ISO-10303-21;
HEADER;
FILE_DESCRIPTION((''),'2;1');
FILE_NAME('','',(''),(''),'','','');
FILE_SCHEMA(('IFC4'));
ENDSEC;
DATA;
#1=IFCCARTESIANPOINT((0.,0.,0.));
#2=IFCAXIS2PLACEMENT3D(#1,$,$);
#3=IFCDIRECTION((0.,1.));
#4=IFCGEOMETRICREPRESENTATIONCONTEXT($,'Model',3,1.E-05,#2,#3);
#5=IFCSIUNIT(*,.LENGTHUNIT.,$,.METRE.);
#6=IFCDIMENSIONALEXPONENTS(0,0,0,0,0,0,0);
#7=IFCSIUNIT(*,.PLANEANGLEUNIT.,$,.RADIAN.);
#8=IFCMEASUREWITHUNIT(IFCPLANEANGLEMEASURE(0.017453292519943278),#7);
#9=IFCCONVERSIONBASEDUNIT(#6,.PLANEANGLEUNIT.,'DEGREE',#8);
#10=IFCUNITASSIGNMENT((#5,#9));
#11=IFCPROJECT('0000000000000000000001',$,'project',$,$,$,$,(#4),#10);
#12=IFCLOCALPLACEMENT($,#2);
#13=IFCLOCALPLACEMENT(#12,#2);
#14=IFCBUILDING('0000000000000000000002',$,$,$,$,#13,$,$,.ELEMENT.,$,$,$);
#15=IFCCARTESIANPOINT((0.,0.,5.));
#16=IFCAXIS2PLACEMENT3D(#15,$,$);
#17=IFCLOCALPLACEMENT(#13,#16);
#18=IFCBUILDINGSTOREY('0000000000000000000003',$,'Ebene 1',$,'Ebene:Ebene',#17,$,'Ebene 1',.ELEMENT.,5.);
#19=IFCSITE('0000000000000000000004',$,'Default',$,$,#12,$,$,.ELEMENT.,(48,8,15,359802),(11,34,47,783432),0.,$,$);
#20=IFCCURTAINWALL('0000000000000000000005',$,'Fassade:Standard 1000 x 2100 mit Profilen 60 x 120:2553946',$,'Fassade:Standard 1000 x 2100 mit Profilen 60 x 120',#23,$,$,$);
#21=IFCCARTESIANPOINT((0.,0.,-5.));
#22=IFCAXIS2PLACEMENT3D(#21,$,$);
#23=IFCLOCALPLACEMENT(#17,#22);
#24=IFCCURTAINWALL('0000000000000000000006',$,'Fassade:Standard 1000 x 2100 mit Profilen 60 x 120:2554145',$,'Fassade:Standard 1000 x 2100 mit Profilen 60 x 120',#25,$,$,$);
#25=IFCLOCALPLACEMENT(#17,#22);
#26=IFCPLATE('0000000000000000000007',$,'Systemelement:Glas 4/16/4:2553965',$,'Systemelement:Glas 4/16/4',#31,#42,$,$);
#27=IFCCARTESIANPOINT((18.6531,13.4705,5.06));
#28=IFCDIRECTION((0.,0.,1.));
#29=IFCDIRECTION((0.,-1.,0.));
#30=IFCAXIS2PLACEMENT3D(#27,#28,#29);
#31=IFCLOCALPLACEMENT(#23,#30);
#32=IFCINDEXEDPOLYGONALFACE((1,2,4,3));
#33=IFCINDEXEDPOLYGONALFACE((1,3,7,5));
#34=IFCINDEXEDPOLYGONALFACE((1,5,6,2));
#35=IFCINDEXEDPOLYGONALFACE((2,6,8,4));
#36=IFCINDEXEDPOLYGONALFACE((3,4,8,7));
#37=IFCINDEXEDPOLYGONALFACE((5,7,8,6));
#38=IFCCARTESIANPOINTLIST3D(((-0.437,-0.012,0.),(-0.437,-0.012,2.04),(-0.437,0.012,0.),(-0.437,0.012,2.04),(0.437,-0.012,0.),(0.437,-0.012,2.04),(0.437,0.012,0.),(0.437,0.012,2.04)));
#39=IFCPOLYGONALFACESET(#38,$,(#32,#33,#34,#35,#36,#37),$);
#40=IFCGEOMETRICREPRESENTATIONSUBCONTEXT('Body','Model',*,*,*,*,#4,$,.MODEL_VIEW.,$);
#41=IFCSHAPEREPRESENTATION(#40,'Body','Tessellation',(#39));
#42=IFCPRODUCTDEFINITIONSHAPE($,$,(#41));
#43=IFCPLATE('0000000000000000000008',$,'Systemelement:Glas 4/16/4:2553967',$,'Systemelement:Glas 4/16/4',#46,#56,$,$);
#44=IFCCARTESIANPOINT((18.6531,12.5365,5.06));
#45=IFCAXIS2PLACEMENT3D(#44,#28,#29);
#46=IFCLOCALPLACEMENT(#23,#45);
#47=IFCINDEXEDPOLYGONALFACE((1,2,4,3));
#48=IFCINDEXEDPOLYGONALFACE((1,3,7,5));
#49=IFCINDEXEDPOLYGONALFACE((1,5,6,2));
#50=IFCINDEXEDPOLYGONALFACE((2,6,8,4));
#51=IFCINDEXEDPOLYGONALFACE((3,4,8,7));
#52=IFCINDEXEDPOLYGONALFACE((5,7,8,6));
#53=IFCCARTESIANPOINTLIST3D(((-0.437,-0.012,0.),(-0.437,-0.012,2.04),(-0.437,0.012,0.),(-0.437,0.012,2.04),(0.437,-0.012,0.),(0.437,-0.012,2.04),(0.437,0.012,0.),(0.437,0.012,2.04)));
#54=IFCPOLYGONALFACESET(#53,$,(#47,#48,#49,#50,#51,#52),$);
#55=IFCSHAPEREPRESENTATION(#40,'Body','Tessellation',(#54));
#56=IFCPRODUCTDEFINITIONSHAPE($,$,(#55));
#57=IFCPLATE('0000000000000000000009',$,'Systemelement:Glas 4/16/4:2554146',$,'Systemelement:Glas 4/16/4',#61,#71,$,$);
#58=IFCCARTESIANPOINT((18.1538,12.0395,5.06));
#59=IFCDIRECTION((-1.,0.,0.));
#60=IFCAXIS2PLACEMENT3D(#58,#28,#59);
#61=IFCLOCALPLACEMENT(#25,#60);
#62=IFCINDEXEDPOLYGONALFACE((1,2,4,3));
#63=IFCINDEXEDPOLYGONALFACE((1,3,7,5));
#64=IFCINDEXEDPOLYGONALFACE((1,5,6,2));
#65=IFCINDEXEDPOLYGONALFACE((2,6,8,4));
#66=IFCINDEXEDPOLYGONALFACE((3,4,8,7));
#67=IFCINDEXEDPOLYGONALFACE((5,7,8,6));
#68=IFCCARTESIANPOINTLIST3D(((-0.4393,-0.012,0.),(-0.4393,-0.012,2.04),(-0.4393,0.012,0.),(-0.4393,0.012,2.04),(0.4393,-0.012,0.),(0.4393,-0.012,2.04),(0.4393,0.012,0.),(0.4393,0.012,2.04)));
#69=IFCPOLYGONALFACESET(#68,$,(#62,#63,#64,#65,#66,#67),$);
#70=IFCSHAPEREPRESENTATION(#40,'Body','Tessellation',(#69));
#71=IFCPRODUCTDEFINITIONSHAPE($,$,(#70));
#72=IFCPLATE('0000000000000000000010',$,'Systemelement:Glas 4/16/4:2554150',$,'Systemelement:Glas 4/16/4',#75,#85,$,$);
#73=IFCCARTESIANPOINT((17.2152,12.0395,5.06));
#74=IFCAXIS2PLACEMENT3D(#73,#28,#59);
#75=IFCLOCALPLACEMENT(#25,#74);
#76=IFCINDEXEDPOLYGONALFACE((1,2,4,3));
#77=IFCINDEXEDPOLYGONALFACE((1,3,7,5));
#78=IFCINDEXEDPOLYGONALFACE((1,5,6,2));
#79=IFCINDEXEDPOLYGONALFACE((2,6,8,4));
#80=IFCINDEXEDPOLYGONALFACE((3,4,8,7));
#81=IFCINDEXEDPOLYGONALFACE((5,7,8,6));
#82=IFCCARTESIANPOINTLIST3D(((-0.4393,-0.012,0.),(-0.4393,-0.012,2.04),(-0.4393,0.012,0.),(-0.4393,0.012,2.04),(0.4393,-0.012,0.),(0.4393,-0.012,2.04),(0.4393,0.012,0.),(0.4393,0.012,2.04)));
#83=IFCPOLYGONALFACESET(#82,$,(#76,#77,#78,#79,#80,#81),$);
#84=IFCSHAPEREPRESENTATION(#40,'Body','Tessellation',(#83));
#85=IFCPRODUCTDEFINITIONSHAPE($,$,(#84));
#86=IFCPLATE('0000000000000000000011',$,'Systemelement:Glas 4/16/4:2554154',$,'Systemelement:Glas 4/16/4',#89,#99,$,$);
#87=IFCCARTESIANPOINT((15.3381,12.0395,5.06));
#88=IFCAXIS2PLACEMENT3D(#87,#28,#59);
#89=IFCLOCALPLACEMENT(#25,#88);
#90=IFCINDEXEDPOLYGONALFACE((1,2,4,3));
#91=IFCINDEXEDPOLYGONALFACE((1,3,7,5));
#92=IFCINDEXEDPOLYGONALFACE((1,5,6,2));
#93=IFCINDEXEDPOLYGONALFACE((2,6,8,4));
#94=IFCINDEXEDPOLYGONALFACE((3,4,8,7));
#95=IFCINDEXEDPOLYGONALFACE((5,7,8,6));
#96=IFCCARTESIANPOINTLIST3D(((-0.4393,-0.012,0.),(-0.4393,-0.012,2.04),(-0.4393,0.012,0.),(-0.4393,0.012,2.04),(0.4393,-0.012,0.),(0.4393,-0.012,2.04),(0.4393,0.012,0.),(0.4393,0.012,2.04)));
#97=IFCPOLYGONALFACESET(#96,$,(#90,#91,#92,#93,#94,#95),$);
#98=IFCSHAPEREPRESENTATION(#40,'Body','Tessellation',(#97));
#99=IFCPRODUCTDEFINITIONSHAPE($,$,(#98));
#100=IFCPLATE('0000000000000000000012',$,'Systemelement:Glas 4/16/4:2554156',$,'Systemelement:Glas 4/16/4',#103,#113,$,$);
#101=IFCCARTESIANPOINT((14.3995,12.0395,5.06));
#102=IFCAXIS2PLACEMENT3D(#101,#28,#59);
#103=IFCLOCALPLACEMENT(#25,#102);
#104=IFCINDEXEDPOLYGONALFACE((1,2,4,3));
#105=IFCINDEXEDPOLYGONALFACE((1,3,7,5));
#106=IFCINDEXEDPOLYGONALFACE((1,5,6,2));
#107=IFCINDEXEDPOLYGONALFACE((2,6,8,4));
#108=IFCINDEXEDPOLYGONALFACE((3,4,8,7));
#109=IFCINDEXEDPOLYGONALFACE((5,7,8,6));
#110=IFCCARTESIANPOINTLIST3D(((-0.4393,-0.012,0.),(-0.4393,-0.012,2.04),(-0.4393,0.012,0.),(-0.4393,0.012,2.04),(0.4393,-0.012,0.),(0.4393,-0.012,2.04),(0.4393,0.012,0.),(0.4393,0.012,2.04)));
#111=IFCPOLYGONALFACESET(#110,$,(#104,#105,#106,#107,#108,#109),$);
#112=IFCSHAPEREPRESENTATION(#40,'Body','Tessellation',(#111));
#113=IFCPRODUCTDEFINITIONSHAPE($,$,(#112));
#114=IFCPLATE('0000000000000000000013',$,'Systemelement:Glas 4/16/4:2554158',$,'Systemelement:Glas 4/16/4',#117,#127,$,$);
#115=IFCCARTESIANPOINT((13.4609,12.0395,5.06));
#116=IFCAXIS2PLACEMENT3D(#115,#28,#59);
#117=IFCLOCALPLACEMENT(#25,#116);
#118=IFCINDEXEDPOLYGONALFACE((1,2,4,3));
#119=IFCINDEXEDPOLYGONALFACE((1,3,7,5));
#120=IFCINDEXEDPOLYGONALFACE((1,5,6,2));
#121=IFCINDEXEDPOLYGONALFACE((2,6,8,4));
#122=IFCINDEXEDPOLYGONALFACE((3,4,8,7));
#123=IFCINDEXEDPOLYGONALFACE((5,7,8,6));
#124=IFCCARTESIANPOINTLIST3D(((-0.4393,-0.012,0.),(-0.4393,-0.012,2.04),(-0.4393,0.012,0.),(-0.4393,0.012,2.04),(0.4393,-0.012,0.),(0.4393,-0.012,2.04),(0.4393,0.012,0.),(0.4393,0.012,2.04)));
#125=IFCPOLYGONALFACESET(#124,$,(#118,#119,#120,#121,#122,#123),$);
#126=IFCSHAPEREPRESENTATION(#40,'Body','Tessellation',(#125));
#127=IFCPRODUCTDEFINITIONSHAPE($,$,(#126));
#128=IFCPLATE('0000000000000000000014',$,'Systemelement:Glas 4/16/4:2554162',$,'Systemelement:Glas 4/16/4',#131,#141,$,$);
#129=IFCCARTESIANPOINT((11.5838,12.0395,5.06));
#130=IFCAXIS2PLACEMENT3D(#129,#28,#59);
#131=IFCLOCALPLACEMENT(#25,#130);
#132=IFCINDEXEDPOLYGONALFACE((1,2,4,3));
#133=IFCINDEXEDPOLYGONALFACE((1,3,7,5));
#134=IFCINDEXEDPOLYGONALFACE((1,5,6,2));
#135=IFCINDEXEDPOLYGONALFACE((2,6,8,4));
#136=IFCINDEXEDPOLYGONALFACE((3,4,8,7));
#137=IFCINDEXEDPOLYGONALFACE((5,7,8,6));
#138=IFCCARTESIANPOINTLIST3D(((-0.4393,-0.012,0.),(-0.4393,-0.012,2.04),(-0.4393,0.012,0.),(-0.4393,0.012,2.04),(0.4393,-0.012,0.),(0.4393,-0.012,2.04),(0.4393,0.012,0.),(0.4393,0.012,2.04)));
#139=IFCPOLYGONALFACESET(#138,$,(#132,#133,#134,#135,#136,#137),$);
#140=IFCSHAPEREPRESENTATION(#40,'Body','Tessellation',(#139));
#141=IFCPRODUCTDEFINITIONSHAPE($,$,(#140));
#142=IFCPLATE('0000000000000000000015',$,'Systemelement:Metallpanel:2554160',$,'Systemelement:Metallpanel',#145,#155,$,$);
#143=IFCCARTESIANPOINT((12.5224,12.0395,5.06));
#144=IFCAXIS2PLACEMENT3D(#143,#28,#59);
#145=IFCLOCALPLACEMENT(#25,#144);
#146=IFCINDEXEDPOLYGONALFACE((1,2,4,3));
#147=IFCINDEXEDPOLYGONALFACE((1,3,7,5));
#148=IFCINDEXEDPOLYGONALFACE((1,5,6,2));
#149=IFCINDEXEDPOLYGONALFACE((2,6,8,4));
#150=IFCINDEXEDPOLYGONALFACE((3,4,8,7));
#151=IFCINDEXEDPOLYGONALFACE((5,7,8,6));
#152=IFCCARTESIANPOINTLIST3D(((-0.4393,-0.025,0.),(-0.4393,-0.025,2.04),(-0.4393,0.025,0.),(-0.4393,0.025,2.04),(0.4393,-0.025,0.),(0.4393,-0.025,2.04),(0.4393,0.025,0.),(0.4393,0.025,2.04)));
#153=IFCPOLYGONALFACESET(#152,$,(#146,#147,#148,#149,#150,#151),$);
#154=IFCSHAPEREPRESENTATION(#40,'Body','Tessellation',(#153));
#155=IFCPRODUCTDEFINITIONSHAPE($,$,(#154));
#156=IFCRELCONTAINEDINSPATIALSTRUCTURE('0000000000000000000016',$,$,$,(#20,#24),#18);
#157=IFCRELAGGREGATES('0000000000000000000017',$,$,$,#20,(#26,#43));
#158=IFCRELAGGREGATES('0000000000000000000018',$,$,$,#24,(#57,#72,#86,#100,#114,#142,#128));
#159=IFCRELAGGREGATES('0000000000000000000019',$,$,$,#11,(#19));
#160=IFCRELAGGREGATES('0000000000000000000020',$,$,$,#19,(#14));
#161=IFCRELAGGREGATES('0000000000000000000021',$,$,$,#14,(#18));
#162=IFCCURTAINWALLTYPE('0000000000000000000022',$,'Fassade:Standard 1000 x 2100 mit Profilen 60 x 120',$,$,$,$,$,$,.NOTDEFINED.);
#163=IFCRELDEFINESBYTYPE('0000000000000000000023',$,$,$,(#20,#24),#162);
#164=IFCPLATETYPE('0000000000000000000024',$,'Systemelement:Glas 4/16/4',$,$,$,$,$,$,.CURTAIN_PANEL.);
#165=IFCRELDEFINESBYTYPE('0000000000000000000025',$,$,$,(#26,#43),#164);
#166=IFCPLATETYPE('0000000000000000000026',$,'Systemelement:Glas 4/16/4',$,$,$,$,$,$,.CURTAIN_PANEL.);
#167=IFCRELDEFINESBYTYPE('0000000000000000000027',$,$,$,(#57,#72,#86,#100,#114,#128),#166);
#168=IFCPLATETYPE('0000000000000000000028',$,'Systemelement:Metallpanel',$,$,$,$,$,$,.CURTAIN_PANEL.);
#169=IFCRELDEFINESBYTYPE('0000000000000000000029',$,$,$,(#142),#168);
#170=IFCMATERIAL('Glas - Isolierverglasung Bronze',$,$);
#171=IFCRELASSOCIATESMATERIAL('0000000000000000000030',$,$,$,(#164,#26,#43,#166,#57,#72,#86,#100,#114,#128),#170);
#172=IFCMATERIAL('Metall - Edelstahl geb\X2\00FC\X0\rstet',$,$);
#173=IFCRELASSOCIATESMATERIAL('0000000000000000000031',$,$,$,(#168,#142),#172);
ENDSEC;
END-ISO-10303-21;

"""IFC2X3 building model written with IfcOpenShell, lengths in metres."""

from ifc_helpers import new_model, entity, si_unit, converted_unit, direction, frame, origin, origin_2d_with_axis, place, context, subcontext, project, spatial, rectangle, extrude, source, transform, mapped, material, type_object, type_shapes, element, aggregate, save


model = new_model("IFC2X3")

# Units and contexts
model_context = context("Model", 3, precision=1e-05, world=origin(), true_north=direction((0.0, 1.0)))
body_context = subcontext(model_context, "Body", "Model", "MODEL_VIEW")
ifc_project = project(units=[si_unit("LENGTHUNIT", "METRE"), converted_unit("PLANEANGLEUNIT", "DEGREE", entity("IfcPlaneAngleMeasure", 0.017453292519943278), si_unit("PLANEANGLEUNIT", "RADIAN"), dimensions=[0, 0, 0, 0, 0, 0, 0])], contexts=[model_context])

# Site, building, storey
site_placement = place(None, origin())
site = spatial("IfcSite", under=ifc_project, at=site_placement, Name="Default", CompositionType="ELEMENT", RefLatitude=(48, 8, 15, 359802), RefLongitude=(11, 34, 47, 783432), RefElevation=0.0)
building_placement = place(site_placement, origin())
building = spatial("IfcBuilding", under=site, at=building_placement, CompositionType="ELEMENT")
storey_placement = place(building_placement, frame((0.0, 0.0, 5.0)))
storey = spatial("IfcBuildingStorey", under=building, at=storey_placement, Name="Ebene 1", ObjectType="Ebene:Ebene", LongName="Ebene 1", CompositionType="ELEMENT", Elevation=5.0)

# Curtain walls
curtain_wall_type = type_object("IfcCurtainWallType", Name="Fassade:Standard 1000 x 2100 mit Profilen 60 x 120", PredefinedType="NOTDEFINED")
curtain_wall_1_placement = place(storey_placement, frame((0.0, 0.0, -5.0)))
curtain_wall_1 = element("IfcCurtainWall", 1, at=curtain_wall_1_placement, inside=storey, type_object=curtain_wall_type, Name="Fassade:Standard 1000 x 2100 mit Profilen 60 x 120:2553946", ObjectType="Fassade:Standard 1000 x 2100 mit Profilen 60 x 120")
curtain_wall_2_placement = place(storey_placement, frame((0.0, 0.0, -5.0)))
curtain_wall_2 = element("IfcCurtainWall", 2, at=curtain_wall_2_placement, inside=storey, type_object=curtain_wall_type, Name="Fassade:Standard 1000 x 2100 mit Profilen 60 x 120:2554145", ObjectType="Fassade:Standard 1000 x 2100 mit Profilen 60 x 120")

# Plates
ifc_material_1 = material(Name="Glas - Isolierverglasung Bronze")
plate_type_1 = type_object("IfcPlateType", Name="Systemelement:Glas 4/16/4", PredefinedType="CURTAIN_PANEL", material=ifc_material_1)
shared_shape_1 = source(origin(), body_context, "Body", "SweptSolid", [
    extrude(rectangle(XDim=0.024, YDim=0.874, at=origin_2d_with_axis()), frame((0.0, 0.0, 0.0), z_axis=(0.0, 0.0, 1.0), x_axis=(0.0, 1.0, 0.0)), (0.0, 0.0, 1.0), 2.04),
])
type_shapes(plate_type_1, [shared_shape_1])
plate_1_placement = place(curtain_wall_1_placement, frame((18.6531, 13.4705, 5.06), z_axis=(0.0, 0.0, 1.0), x_axis=(0.0, -1.0, 0.0)))
plate_1 = element("IfcPlate", 3, at=plate_1_placement, type_object=plate_type_1, material=ifc_material_1, Name="Systemelement:Glas 4/16/4:2553965", ObjectType="Systemelement:Glas 4/16/4", context=body_context, shape_type="MappedRepresentation", body=[
    mapped(shared_shape_1, transform((0.0, 0.0, 0.0), scale=1.0)),
])
plate_2_placement = place(curtain_wall_1_placement, frame((18.6531, 12.5365, 5.06), z_axis=(0.0, 0.0, 1.0), x_axis=(0.0, -1.0, 0.0)))
plate_2 = element("IfcPlate", 4, at=plate_2_placement, type_object=plate_type_1, material=ifc_material_1, Name="Systemelement:Glas 4/16/4:2553967", ObjectType="Systemelement:Glas 4/16/4", context=body_context, shape_type="MappedRepresentation", body=[
    mapped(shared_shape_1, transform((0.0, 0.0, 0.0), scale=1.0)),
])
aggregate(curtain_wall_1, [plate_1, plate_2])
plate_type_2 = type_object("IfcPlateType", Name="Systemelement:Glas 4/16/4", PredefinedType="CURTAIN_PANEL", material=ifc_material_1)
shared_shape_2 = source(origin(), body_context, "Body", "SweptSolid", [
    extrude(rectangle(XDim=0.024, YDim=0.8786, at=origin_2d_with_axis()), frame((0.0, 0.0, 0.0), z_axis=(0.0, 0.0, 1.0), x_axis=(0.0, 1.0, 0.0)), (0.0, 0.0, 1.0), 2.04),
])
type_shapes(plate_type_2, [shared_shape_2])
plate_3_placement = place(curtain_wall_2_placement, frame((18.1538, 12.0395, 5.06), z_axis=(0.0, 0.0, 1.0), x_axis=(-1.0, 0.0, 0.0)))
plate_3 = element("IfcPlate", 5, at=plate_3_placement, type_object=plate_type_2, material=ifc_material_1, Name="Systemelement:Glas 4/16/4:2554146", ObjectType="Systemelement:Glas 4/16/4", context=body_context, shape_type="MappedRepresentation", body=[
    mapped(shared_shape_2, transform((0.0, 0.0, 0.0), scale=1.0)),
])
plate_4_placement = place(curtain_wall_2_placement, frame((17.2152, 12.0395, 5.06), z_axis=(0.0, 0.0, 1.0), x_axis=(-1.0, 0.0, 0.0)))
plate_4 = element("IfcPlate", 6, at=plate_4_placement, type_object=plate_type_2, material=ifc_material_1, Name="Systemelement:Glas 4/16/4:2554150", ObjectType="Systemelement:Glas 4/16/4", context=body_context, shape_type="MappedRepresentation", body=[
    mapped(shared_shape_2, transform((0.0, 0.0, 0.0), scale=1.0)),
])
plate_5_placement = place(curtain_wall_2_placement, frame((15.3381, 12.0395, 5.06), z_axis=(0.0, 0.0, 1.0), x_axis=(-1.0, 0.0, 0.0)))
plate_5 = element("IfcPlate", 7, at=plate_5_placement, type_object=plate_type_2, material=ifc_material_1, Name="Systemelement:Glas 4/16/4:2554154", ObjectType="Systemelement:Glas 4/16/4", context=body_context, shape_type="MappedRepresentation", body=[
    mapped(shared_shape_2, transform((0.0, 0.0, 0.0), scale=1.0)),
])
plate_6_placement = place(curtain_wall_2_placement, frame((14.3995, 12.0395, 5.06), z_axis=(0.0, 0.0, 1.0), x_axis=(-1.0, 0.0, 0.0)))
plate_6 = element("IfcPlate", 8, at=plate_6_placement, type_object=plate_type_2, material=ifc_material_1, Name="Systemelement:Glas 4/16/4:2554156", ObjectType="Systemelement:Glas 4/16/4", context=body_context, shape_type="MappedRepresentation", body=[
    mapped(shared_shape_2, transform((0.0, 0.0, 0.0), scale=1.0)),
])
plate_7_placement = place(curtain_wall_2_placement, frame((13.4609, 12.0395, 5.06), z_axis=(0.0, 0.0, 1.0), x_axis=(-1.0, 0.0, 0.0)))
plate_7 = element("IfcPlate", 9, at=plate_7_placement, type_object=plate_type_2, material=ifc_material_1, Name="Systemelement:Glas 4/16/4:2554158", ObjectType="Systemelement:Glas 4/16/4", context=body_context, shape_type="MappedRepresentation", body=[
    mapped(shared_shape_2, transform((0.0, 0.0, 0.0), scale=1.0)),
])
plate_8_placement = place(curtain_wall_2_placement, frame((11.5838, 12.0395, 5.06), z_axis=(0.0, 0.0, 1.0), x_axis=(-1.0, 0.0, 0.0)))
plate_8 = element("IfcPlate", 10, at=plate_8_placement, type_object=plate_type_2, material=ifc_material_1, Name="Systemelement:Glas 4/16/4:2554162", ObjectType="Systemelement:Glas 4/16/4", context=body_context, shape_type="MappedRepresentation", body=[
    mapped(shared_shape_2, transform((0.0, 0.0, 0.0), scale=1.0)),
])
ifc_material_2 = material(Name="Metall - Edelstahl gebürstet")
plate_type_3 = type_object("IfcPlateType", Name="Systemelement:Metallpanel", PredefinedType="CURTAIN_PANEL", material=ifc_material_2)
shared_shape_3 = source(origin(), body_context, "Body", "SweptSolid", [
    extrude(rectangle(XDim=0.05, YDim=0.8786, at=origin_2d_with_axis()), frame((0.0, 0.0, 0.0), z_axis=(0.0, 0.0, 1.0), x_axis=(0.0, 1.0, 0.0)), (0.0, 0.0, 1.0), 2.04),
])
type_shapes(plate_type_3, [shared_shape_3])
plate_9_placement = place(curtain_wall_2_placement, frame((12.5224, 12.0395, 5.06), z_axis=(0.0, 0.0, 1.0), x_axis=(-1.0, 0.0, 0.0)))
plate_9 = element("IfcPlate", 11, at=plate_9_placement, type_object=plate_type_3, material=ifc_material_2, Name="Systemelement:Metallpanel:2554160", ObjectType="Systemelement:Metallpanel", context=body_context, shape_type="MappedRepresentation", body=[
    mapped(shared_shape_3, transform((0.0, 0.0, 0.0), scale=1.0)),
])
aggregate(curtain_wall_2, [plate_3, plate_4, plate_5, plate_6, plate_7, plate_9, plate_8])

save(model, "model.ifc")
